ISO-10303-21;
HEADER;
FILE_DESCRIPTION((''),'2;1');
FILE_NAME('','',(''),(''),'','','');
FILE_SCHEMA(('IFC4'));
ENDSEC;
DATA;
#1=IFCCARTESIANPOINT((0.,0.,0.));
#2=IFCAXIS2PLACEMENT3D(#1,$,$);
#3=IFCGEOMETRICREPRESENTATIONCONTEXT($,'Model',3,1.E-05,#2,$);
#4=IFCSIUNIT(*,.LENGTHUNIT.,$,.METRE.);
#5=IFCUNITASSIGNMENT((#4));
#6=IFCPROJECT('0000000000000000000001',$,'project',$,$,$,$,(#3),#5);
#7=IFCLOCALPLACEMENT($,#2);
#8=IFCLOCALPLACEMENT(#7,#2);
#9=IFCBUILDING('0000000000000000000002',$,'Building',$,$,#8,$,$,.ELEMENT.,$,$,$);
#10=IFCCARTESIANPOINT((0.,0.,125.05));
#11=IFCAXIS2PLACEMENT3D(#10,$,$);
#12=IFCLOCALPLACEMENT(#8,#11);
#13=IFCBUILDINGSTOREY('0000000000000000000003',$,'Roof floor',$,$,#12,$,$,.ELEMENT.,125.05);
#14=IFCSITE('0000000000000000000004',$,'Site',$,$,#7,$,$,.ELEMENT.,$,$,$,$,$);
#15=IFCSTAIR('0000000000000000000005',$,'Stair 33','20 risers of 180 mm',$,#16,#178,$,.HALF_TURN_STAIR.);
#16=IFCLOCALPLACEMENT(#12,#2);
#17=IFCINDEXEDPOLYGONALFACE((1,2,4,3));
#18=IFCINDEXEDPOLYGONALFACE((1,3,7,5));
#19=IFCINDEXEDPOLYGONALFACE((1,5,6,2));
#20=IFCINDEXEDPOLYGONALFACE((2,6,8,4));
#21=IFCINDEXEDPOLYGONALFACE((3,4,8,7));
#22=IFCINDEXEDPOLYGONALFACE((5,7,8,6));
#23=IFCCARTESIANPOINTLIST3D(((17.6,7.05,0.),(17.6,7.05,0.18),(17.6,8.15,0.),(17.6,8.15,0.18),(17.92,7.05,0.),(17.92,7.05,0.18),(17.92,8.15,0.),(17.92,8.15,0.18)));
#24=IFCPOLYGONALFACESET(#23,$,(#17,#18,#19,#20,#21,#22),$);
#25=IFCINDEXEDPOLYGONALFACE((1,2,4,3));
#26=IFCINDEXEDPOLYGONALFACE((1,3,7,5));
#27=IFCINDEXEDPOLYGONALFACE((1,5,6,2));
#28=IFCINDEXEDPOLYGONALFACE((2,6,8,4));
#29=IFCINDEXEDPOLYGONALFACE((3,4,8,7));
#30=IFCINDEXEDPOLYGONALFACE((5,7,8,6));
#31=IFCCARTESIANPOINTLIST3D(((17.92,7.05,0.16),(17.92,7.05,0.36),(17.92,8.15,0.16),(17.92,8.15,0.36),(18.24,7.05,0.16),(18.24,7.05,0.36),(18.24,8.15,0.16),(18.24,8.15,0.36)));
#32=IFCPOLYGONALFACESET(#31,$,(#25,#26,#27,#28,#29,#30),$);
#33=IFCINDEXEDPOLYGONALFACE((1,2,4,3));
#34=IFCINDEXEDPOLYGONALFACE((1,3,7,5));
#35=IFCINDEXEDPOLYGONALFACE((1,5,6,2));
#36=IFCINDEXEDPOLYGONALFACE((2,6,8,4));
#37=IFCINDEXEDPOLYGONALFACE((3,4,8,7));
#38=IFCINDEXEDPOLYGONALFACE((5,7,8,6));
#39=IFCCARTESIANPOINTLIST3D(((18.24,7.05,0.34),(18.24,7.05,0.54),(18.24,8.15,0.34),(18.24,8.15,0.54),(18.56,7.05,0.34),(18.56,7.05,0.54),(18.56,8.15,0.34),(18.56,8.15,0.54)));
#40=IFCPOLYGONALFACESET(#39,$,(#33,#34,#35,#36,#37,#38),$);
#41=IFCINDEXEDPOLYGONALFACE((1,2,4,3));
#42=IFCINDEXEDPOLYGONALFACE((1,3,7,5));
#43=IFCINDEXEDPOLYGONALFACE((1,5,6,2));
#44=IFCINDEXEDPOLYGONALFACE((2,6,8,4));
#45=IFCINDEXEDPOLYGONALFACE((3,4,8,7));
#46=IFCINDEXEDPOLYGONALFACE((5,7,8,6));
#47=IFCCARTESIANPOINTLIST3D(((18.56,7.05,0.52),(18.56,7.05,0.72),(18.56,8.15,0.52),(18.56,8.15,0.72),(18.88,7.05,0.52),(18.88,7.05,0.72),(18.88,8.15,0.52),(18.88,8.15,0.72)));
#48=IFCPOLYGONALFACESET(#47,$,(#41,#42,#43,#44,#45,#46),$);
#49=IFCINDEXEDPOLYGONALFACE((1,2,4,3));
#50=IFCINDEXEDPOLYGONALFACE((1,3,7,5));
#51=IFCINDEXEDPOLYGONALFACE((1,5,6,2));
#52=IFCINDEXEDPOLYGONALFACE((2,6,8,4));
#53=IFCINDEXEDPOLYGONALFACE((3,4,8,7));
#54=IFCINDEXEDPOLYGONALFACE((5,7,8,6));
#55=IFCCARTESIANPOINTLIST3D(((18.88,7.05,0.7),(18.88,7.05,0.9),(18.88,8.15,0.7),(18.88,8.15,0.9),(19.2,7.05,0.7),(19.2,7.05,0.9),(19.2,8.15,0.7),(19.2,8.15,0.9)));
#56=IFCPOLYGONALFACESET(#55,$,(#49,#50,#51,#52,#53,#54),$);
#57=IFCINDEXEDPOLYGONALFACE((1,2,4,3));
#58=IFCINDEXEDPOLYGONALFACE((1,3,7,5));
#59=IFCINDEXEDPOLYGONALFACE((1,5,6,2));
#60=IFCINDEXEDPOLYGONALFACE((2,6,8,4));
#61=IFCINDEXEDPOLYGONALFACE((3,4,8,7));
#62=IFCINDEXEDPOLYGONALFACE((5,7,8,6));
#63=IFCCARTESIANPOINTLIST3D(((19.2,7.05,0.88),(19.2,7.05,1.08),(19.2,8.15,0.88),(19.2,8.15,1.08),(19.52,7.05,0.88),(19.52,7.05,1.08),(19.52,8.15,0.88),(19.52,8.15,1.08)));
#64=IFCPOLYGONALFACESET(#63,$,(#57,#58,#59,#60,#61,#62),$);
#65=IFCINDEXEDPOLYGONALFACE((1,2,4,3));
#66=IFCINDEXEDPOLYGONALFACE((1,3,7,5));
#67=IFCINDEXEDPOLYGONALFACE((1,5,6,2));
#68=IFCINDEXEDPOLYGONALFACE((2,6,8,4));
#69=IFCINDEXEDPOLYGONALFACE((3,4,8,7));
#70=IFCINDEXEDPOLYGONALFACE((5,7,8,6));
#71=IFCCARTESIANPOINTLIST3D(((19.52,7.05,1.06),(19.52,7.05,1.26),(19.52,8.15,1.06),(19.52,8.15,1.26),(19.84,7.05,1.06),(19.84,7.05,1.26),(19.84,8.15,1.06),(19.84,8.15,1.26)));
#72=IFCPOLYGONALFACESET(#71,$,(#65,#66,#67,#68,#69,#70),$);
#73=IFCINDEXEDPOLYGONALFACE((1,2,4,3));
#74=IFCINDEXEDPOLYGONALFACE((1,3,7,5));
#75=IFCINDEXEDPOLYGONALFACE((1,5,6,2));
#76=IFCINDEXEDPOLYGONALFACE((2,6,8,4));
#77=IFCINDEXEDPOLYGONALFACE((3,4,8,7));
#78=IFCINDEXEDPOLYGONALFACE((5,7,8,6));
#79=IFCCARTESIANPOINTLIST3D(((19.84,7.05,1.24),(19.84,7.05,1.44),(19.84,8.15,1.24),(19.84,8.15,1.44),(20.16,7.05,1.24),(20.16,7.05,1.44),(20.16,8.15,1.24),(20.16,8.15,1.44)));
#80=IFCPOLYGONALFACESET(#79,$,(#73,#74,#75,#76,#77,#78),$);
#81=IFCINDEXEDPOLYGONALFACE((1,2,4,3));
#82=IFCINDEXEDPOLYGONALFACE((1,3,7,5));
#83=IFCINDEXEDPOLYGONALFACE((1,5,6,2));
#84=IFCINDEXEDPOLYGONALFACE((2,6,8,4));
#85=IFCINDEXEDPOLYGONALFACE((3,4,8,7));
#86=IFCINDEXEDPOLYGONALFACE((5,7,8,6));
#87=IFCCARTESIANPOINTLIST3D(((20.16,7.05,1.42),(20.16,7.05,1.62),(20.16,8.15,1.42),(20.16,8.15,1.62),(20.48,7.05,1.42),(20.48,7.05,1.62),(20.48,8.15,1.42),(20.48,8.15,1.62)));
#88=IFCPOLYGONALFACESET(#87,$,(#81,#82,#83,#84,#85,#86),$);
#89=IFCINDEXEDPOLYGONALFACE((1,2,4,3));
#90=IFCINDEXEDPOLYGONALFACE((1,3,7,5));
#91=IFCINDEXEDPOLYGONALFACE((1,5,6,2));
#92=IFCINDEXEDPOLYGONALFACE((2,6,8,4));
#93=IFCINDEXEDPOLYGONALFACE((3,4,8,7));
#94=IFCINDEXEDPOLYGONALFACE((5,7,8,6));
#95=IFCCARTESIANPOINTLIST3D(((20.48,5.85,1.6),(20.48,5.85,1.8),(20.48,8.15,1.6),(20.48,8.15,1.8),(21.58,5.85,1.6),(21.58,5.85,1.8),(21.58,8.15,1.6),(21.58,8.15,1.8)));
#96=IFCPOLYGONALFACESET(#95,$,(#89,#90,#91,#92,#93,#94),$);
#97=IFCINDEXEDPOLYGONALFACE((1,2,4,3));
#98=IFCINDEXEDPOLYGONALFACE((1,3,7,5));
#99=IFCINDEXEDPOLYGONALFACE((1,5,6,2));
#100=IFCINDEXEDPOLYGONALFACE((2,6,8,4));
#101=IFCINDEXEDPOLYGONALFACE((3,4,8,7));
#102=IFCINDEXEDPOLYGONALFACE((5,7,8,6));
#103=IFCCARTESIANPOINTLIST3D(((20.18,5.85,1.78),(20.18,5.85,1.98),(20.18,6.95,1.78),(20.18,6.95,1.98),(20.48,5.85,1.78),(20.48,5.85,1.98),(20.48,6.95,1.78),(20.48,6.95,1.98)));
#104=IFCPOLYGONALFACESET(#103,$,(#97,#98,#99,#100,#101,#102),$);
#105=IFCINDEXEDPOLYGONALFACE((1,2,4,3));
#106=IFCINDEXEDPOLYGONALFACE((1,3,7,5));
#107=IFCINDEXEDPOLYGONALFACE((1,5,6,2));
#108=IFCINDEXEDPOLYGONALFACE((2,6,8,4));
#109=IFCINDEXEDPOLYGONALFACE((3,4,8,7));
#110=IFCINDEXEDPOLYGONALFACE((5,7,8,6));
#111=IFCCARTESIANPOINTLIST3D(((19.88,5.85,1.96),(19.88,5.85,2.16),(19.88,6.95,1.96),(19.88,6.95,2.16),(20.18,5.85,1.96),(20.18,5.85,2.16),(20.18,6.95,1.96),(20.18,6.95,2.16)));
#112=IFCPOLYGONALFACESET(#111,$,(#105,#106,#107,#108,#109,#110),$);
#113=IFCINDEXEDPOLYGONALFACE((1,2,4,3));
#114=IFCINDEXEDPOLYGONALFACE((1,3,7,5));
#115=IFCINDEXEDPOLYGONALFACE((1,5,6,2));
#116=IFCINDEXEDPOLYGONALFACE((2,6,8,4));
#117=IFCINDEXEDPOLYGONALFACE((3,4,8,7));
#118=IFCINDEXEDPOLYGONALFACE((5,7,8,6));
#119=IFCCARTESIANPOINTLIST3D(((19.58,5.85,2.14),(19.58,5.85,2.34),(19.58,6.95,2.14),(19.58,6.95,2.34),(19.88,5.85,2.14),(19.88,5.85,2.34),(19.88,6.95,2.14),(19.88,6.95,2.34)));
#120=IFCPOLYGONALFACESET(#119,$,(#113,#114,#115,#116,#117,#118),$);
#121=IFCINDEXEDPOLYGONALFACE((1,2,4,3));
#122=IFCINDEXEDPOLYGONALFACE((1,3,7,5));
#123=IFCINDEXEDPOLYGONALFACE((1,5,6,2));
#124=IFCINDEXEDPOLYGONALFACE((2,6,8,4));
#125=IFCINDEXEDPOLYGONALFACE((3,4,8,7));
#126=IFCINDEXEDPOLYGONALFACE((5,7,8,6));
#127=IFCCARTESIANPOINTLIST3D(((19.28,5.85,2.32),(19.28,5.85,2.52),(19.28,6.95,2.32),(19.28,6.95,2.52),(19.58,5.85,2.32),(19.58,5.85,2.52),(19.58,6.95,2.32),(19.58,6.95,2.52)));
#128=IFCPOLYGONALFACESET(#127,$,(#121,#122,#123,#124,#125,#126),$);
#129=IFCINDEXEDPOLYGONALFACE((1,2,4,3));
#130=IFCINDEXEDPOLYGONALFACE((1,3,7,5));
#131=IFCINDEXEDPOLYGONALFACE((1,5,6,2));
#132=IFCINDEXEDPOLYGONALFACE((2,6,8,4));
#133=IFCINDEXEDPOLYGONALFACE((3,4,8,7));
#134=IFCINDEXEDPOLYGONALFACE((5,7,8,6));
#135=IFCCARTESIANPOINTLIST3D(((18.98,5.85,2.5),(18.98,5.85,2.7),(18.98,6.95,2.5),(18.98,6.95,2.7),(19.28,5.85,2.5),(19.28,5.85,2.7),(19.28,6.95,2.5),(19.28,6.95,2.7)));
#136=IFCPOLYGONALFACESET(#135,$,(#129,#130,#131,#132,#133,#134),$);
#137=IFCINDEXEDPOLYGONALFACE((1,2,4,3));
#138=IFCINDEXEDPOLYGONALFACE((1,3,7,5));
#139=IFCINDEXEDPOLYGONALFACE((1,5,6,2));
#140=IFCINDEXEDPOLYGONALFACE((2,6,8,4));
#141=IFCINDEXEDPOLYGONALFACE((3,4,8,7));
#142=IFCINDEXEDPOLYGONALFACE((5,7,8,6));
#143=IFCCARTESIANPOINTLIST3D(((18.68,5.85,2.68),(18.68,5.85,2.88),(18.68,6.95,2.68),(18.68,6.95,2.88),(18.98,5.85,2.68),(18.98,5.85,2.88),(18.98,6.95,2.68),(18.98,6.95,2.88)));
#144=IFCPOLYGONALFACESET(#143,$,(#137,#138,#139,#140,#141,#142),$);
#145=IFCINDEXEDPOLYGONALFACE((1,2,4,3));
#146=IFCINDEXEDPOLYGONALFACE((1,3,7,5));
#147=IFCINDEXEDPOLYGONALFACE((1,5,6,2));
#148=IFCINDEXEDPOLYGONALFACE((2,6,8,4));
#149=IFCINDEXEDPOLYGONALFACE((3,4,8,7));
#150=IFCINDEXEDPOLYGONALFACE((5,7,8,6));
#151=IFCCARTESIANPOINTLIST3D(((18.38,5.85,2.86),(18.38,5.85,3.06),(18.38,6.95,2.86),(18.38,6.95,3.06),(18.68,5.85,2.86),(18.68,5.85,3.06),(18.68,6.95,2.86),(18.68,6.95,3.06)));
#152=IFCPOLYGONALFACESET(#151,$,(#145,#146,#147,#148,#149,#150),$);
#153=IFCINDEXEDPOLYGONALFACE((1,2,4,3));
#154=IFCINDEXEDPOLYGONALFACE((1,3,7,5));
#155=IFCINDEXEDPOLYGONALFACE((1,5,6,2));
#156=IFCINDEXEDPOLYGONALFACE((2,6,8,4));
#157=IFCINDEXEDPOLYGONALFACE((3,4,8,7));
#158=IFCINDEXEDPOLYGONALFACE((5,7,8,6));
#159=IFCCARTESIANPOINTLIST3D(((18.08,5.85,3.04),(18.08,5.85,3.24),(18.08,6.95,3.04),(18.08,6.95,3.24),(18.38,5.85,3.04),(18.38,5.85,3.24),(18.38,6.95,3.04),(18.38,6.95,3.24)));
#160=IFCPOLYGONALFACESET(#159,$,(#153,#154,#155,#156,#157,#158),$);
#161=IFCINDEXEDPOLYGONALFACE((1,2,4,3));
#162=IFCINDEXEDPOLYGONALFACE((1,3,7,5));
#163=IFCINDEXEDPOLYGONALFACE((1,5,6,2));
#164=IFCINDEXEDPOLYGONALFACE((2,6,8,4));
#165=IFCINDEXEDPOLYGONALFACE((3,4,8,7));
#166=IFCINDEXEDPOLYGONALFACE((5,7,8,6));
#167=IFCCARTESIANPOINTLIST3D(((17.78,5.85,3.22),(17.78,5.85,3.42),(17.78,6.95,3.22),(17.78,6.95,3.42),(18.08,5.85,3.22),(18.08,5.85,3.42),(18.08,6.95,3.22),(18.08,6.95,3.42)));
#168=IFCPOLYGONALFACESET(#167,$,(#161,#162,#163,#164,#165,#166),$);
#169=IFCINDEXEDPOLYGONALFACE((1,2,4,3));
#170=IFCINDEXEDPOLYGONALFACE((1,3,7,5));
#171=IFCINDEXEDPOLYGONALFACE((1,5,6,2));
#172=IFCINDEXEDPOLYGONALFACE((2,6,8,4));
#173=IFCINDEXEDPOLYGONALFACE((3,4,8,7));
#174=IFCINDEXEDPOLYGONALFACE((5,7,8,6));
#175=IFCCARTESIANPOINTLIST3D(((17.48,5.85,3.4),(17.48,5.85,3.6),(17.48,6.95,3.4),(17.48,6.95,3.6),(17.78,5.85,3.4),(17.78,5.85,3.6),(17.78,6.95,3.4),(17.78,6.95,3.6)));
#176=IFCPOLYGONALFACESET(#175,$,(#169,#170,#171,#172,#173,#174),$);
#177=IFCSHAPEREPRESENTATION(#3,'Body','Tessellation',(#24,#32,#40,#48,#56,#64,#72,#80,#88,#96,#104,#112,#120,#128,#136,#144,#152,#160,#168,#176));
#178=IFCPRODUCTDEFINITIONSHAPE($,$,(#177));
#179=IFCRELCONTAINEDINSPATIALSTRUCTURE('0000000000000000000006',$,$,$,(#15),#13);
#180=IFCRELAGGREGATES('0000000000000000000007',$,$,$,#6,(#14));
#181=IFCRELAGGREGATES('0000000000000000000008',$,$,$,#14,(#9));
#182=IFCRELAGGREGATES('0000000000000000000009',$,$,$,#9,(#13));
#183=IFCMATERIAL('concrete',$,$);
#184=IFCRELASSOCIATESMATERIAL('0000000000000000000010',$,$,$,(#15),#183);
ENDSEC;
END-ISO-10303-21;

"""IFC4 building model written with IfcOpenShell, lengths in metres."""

from ifc_helpers import new_model, si_unit, frame, origin, place, context, project, spatial, polyline, outline, extrude, material, element, save


model = new_model("IFC4")

# Units and contexts
model_context = context("Model", 3, precision=1e-05, world=origin())
ifc_project = project(units=[si_unit("LENGTHUNIT", "METRE")], contexts=[model_context])

# Site, building, storey
site_placement = place(None, origin())
site = spatial("IfcSite", under=ifc_project, at=site_placement, Name="Site", CompositionType="ELEMENT")
building_placement = place(site_placement, origin())
building = spatial("IfcBuilding", under=site, at=building_placement, Name="Building", CompositionType="ELEMENT")
storey_placement = place(building_placement, frame((0.0, 0.0, 125.05)))
storey = spatial("IfcBuildingStorey", under=building, at=storey_placement, Name="Roof floor", CompositionType="ELEMENT", Elevation=125.05)

# Shared definitions
ifc_material = material(Name="concrete")

# Stair
stair_1_placement = place(storey_placement, frame((17.6, 7.6, 0.0), z_axis=(0.0, 0.0, 1.0), x_axis=(1.0, 0.0, 0.0)))
element("IfcStair", 1, at=stair_1_placement, inside=storey, material=ifc_material, Name="Stair 33", Description="20 risers of 180 mm", PredefinedType="HALF_TURN_STAIR", context=model_context, shape_type="SweptSolid", body=[
    extrude(outline(polyline([(0.0, -0.55), (0.32, -0.55), (0.32, 0.55), (0.0, 0.55), (0.0, -0.55)])), origin(), (0.0, 0.0, 1.0), 0.18),
    extrude(outline(polyline([(0.32, -0.55), (0.64, -0.55), (0.64, 0.55), (0.32, 0.55), (0.32, -0.55)])), frame((0.0, 0.0, 0.16)), (0.0, 0.0, 1.0), 0.2),
    extrude(outline(polyline([(0.64, -0.55), (0.96, -0.55), (0.96, 0.55), (0.64, 0.55), (0.64, -0.55)])), frame((0.0, 0.0, 0.34)), (0.0, 0.0, 1.0), 0.2),
    extrude(outline(polyline([(0.96, -0.55), (1.28, -0.55), (1.28, 0.55), (0.96, 0.55), (0.96, -0.55)])), frame((0.0, 0.0, 0.52)), (0.0, 0.0, 1.0), 0.2),
    extrude(outline(polyline([(1.28, -0.55), (1.6, -0.55), (1.6, 0.55), (1.28, 0.55), (1.28, -0.55)])), frame((0.0, 0.0, 0.7)), (0.0, 0.0, 1.0), 0.2),
    extrude(outline(polyline([(1.6, -0.55), (1.92, -0.55), (1.92, 0.55), (1.6, 0.55), (1.6, -0.55)])), frame((0.0, 0.0, 0.88)), (0.0, 0.0, 1.0), 0.2),
    extrude(outline(polyline([(1.92, -0.55), (2.24, -0.55), (2.24, 0.55), (1.92, 0.55), (1.92, -0.55)])), frame((0.0, 0.0, 1.06)), (0.0, 0.0, 1.0), 0.2),
    extrude(outline(polyline([(2.24, -0.55), (2.56, -0.55), (2.56, 0.55), (2.24, 0.55), (2.24, -0.55)])), frame((0.0, 0.0, 1.24)), (0.0, 0.0, 1.0), 0.2),
    extrude(outline(polyline([(2.56, -0.55), (2.88, -0.55), (2.88, 0.55), (2.56, 0.55), (2.56, -0.55)])), frame((0.0, 0.0, 1.42)), (0.0, 0.0, 1.0), 0.2),
    extrude(outline(polyline([(2.88, -1.75), (3.98, -1.75), (3.98, 0.55), (2.88, 0.55), (2.88, -1.75)])), frame((0.0, 0.0, 1.6)), (0.0, 0.0, 1.0), 0.2),
    extrude(outline(polyline([(2.58, -1.75), (2.88, -1.75), (2.88, -0.65), (2.58, -0.65), (2.58, -1.75)])), frame((0.0, 0.0, 1.78)), (0.0, 0.0, 1.0), 0.2),
    extrude(outline(polyline([(2.28, -1.75), (2.58, -1.75), (2.58, -0.65), (2.28, -0.65), (2.28, -1.75)])), frame((0.0, 0.0, 1.96)), (0.0, 0.0, 1.0), 0.2),
    extrude(outline(polyline([(1.98, -1.75), (2.28, -1.75), (2.28, -0.65), (1.98, -0.65), (1.98, -1.75)])), frame((0.0, 0.0, 2.14)), (0.0, 0.0, 1.0), 0.2),
    extrude(outline(polyline([(1.68, -1.75), (1.98, -1.75), (1.98, -0.65), (1.68, -0.65), (1.68, -1.75)])), frame((0.0, 0.0, 2.32)), (0.0, 0.0, 1.0), 0.2),
    extrude(outline(polyline([(1.38, -1.75), (1.68, -1.75), (1.68, -0.65), (1.38, -0.65), (1.38, -1.75)])), frame((0.0, 0.0, 2.5)), (0.0, 0.0, 1.0), 0.2),
    extrude(outline(polyline([(1.08, -1.75), (1.38, -1.75), (1.38, -0.65), (1.08, -0.65), (1.08, -1.75)])), frame((0.0, 0.0, 2.68)), (0.0, 0.0, 1.0), 0.2),
    extrude(outline(polyline([(0.78, -1.75), (1.08, -1.75), (1.08, -0.65), (0.78, -0.65), (0.78, -1.75)])), frame((0.0, 0.0, 2.86)), (0.0, 0.0, 1.0), 0.2),
    extrude(outline(polyline([(0.48, -1.75), (0.78, -1.75), (0.78, -0.65), (0.48, -0.65), (0.48, -1.75)])), frame((0.0, 0.0, 3.04)), (0.0, 0.0, 1.0), 0.2),
    extrude(outline(polyline([(0.18, -1.75), (0.48, -1.75), (0.48, -0.65), (0.18, -0.65), (0.18, -1.75)])), frame((0.0, 0.0, 3.22)), (0.0, 0.0, 1.0), 0.2),
    extrude(outline(polyline([(-0.12, -1.75), (0.18, -1.75), (0.18, -0.65), (-0.12, -0.65), (-0.12, -1.75)])), frame((0.0, 0.0, 3.4)), (0.0, 0.0, 1.0), 0.2),
])

save(model, "model.ifc")
